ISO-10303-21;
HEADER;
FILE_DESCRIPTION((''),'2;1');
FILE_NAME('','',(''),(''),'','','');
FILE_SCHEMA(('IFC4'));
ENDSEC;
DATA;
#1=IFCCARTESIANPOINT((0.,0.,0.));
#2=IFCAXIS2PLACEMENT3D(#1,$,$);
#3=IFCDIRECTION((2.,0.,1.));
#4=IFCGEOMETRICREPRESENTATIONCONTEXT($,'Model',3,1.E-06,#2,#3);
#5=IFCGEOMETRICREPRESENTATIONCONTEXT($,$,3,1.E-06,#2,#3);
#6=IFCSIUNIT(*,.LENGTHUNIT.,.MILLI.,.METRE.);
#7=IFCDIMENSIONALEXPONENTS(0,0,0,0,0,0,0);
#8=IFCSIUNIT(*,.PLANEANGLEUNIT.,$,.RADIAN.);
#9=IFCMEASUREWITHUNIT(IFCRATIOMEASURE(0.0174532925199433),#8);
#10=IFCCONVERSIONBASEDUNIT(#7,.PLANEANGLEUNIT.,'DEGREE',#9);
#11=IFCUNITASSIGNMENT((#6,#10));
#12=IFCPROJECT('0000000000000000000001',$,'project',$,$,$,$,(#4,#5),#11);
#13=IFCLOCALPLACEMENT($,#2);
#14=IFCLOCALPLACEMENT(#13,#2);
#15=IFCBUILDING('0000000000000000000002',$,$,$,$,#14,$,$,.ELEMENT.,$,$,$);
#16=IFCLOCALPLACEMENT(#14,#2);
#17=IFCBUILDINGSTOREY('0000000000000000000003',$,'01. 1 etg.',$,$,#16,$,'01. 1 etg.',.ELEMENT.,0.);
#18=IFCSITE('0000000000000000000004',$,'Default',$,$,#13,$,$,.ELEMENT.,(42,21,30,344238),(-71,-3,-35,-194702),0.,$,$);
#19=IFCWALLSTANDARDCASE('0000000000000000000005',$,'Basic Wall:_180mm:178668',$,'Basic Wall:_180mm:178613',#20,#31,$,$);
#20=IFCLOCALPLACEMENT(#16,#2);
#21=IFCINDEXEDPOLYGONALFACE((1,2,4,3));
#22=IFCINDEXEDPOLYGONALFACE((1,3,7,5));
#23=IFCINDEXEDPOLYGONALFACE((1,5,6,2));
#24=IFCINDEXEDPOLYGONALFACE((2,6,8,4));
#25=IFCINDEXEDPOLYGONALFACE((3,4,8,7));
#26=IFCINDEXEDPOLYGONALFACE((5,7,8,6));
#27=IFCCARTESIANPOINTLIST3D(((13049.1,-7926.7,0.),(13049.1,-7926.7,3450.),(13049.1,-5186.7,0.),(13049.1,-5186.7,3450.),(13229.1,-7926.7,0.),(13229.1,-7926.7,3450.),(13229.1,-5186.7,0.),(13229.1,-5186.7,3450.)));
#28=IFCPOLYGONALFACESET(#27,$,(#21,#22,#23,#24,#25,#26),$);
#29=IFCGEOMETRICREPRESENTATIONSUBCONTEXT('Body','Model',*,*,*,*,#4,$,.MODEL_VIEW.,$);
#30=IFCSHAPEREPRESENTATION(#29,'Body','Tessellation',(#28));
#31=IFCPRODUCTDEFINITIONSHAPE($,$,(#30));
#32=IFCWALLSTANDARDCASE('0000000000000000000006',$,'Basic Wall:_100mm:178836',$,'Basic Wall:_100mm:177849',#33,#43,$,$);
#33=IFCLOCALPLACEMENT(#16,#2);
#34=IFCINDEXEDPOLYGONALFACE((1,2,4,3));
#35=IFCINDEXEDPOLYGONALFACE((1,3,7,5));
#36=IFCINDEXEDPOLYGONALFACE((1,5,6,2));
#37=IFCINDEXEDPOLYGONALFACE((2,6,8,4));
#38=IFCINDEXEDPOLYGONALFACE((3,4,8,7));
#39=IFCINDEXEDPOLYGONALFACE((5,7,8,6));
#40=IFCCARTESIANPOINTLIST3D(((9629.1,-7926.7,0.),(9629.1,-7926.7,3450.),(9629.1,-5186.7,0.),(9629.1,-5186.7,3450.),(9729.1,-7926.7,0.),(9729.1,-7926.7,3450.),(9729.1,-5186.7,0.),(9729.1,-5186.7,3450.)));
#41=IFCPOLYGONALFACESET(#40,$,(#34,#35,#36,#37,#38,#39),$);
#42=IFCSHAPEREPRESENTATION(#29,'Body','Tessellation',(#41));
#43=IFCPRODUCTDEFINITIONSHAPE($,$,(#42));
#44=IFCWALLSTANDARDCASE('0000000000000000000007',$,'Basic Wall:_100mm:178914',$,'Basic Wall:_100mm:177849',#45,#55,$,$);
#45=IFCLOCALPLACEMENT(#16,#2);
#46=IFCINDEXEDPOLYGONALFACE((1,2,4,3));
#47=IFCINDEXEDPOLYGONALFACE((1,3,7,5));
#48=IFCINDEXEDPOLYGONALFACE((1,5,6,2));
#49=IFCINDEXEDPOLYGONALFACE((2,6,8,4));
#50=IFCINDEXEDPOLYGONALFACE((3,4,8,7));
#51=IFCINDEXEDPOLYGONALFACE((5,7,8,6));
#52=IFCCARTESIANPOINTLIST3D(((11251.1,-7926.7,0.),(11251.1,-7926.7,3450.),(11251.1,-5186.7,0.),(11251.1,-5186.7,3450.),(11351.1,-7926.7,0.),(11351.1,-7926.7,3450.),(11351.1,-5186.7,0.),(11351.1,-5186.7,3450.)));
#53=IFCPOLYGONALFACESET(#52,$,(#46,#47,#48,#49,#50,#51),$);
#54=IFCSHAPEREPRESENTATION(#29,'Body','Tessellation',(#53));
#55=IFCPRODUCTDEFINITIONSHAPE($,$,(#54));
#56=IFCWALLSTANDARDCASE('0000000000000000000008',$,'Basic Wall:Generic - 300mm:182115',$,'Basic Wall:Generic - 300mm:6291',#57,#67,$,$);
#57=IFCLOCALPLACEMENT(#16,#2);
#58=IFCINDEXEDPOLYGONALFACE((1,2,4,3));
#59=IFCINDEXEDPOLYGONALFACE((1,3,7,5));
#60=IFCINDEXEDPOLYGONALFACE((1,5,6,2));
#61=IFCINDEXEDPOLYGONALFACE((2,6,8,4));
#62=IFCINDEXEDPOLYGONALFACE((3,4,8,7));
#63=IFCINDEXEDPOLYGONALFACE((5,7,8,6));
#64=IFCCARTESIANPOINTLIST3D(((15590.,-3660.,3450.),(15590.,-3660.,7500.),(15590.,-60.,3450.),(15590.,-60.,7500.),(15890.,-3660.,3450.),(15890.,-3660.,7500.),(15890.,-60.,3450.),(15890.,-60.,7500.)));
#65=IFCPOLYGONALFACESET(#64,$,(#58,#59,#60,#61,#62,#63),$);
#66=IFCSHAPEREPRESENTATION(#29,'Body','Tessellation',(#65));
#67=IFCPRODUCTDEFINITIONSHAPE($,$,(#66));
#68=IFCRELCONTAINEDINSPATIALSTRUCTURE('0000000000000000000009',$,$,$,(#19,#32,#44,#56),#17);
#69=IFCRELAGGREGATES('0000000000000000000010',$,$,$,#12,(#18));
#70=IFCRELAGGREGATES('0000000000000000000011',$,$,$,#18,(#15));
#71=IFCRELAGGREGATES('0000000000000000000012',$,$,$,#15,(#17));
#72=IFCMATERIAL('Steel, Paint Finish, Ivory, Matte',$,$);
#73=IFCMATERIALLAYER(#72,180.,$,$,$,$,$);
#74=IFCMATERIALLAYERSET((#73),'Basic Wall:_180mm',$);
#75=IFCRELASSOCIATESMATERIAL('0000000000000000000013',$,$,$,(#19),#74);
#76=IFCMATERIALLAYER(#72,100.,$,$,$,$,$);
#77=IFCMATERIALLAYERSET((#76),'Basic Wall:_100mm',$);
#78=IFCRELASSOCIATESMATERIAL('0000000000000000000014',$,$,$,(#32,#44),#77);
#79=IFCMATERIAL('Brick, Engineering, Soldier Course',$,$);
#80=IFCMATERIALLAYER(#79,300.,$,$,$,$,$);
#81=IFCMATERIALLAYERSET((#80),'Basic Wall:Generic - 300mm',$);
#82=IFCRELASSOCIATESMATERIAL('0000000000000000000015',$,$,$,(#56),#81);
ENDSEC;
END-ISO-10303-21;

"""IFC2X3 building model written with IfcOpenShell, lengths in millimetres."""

from ifc_helpers import new_model, entity, si_unit, converted_unit, direction, frame, frame_2d, origin, place, context, subcontext, project, spatial, polyline, rectangle, extrude, clip, bounded_halfspace, material, layer, layer_set, layer_usage, element, save


model = new_model("IFC2X3")

# Units and contexts
model_context = context("Model", 3, precision=1e-06, world=origin(), true_north=direction((2.0, 0.0, 1.0)))
context_of_model = context(None, 3, precision=1e-06, world=origin(), true_north=direction((2.0, 0.0, 1.0)))
body_context = subcontext(model_context, "Body", "Model", "MODEL_VIEW")
ifc_project = project(units=[si_unit("LENGTHUNIT", "METRE", prefix="MILLI"), converted_unit("PLANEANGLEUNIT", "DEGREE", entity("IfcRatioMeasure", 0.0174532925199433), si_unit("PLANEANGLEUNIT", "RADIAN"), dimensions=[0, 0, 0, 0, 0, 0, 0])], contexts=[model_context, context_of_model])

# Site, building, storey
site_placement = place(None, origin())
site = spatial("IfcSite", under=ifc_project, at=site_placement, Name="Default", CompositionType="ELEMENT", RefLatitude=(42, 21, 30, 344238), RefLongitude=(-71, -3, -35, -194702), RefElevation=0.0)
building_placement = place(site_placement, origin())
building = spatial("IfcBuilding", under=site, at=building_placement, CompositionType="ELEMENT")
storey_placement = place(building_placement, origin())
storey = spatial("IfcBuildingStorey", under=building, at=storey_placement, Name="01. 1 etg.", LongName="01. 1 etg.", CompositionType="ELEMENT", Elevation=0.0)

# Shared definitions
ifc_material_1 = material(Name="Steel, Paint Finish, Ivory, Matte")
ifc_layer_1 = layer(ifc_material_1, 100.0)
ifc_layer_set_1 = layer_set([ifc_layer_1], Name="Basic Wall:_100mm")

# Shared definitions
ifc_layer_2 = layer(ifc_material_1, 180.0)
ifc_layer_set_2 = layer_set([ifc_layer_2], Name="Basic Wall:_180mm")

# Walls
ifc_layer_usage_1 = layer_usage(ifc_layer_set_2, "AXIS2", "NEGATIVE", 90.0)
wall_1_placement = place(storey_placement, frame((13139.1, -5186.7, 0.0), z_axis=(0.0, 0.0, 1.0), x_axis=(0.0, -1.0, 0.0)))
element("IfcWallStandardCase", 1, at=wall_1_placement, inside=storey, material=ifc_layer_usage_1, Name="Basic Wall:_180mm:178668", ObjectType="Basic Wall:_180mm:178613", context=body_context, shape_type="Clipping", body=[
    clip(extrude(rectangle(XDim=2740.0, YDim=180.0, at=frame_2d((1370.0, 0.0), x_axis=(-1.0, 0.0))), origin(), (0.0, 0.0, 1.0), 3450.0), bounded_halfspace(frame((0.0, -90.0, 3450.0), z_axis=(0.0, 0.0, -1.0), x_axis=(1.0, 0.0, 0.0)), True, frame((0.0, -90.0, 3450.0)), polyline([(0.0, 0.0), (2740.0, 0.0), (2740.0, 180.0), (0.0, 180.0), (0.0, 0.0)]))),
])
ifc_layer_usage_2 = layer_usage(ifc_layer_set_1, "AXIS2", "POSITIVE", -50.0)
wall_2_placement = place(storey_placement, frame((9679.1, -5186.7, 0.0), z_axis=(0.0, 0.0, 1.0), x_axis=(0.0, -1.0, 0.0)))
element("IfcWallStandardCase", 2, at=wall_2_placement, inside=storey, material=ifc_layer_usage_2, Name="Basic Wall:_100mm:178836", ObjectType="Basic Wall:_100mm:177849", context=body_context, shape_type="Clipping", body=[
    clip(extrude(rectangle(XDim=2740.0, YDim=100.0, at=frame_2d((1370.0, 0.0), x_axis=(-1.0, 0.0))), origin(), (0.0, 0.0, 1.0), 3450.0), bounded_halfspace(frame((0.0, -50.0, 3450.0), z_axis=(0.0, 0.0, -1.0), x_axis=(1.0, 0.0, 0.0)), True, frame((0.0, -50.0, 3450.0)), polyline([(0.0, 0.0), (2740.0, 0.0), (2740.0, 100.0), (0.0, 100.0), (0.0, 0.0)]))),
])
ifc_layer_usage_3 = layer_usage(ifc_layer_set_1, "AXIS2", "NEGATIVE", 50.0)
wall_3_placement = place(storey_placement, frame((11301.1, -5186.7, 0.0), z_axis=(0.0, 0.0, 1.0), x_axis=(0.0, -1.0, 0.0)))
element("IfcWallStandardCase", 3, at=wall_3_placement, inside=storey, material=ifc_layer_usage_3, Name="Basic Wall:_100mm:178914", ObjectType="Basic Wall:_100mm:177849", context=body_context, shape_type="Clipping", body=[
    clip(extrude(rectangle(XDim=2740.0, YDim=100.0, at=frame_2d((1370.0, 0.0), x_axis=(-1.0, 0.0))), origin(), (0.0, 0.0, 1.0), 3450.0), bounded_halfspace(frame((0.0, -50.0, 3450.0), z_axis=(0.0, 0.0, -1.0), x_axis=(1.0, 0.0, 0.0)), True, frame((0.0, -50.0, 3450.0)), polyline([(0.0, 0.0), (2740.0, 0.0), (2740.0, 100.0), (0.0, 100.0), (0.0, 0.0)]))),
])
ifc_material_2 = material(Name="Brick, Engineering, Soldier Course")
ifc_layer_3 = layer(ifc_material_2, 300.0)
ifc_layer_set_3 = layer_set([ifc_layer_3], Name="Basic Wall:Generic - 300mm")
ifc_layer_usage_4 = layer_usage(ifc_layer_set_3, "AXIS2", "POSITIVE", -150.0)
wall_4_placement = place(storey_placement, frame((15740.0, -3660.0, 3450.0), z_axis=(0.0, 0.0, 1.0), x_axis=(0.0, 1.0, 0.0)))
element("IfcWallStandardCase", 4, at=wall_4_placement, inside=storey, material=ifc_layer_usage_4, Name="Basic Wall:Generic - 300mm:182115", ObjectType="Basic Wall:Generic - 300mm:6291", context=body_context, shape_type="SweptSolid", body=[
    extrude(rectangle(XDim=3600.0, YDim=300.0, at=frame_2d((1800.0, 0.0), x_axis=(-1.0, 0.0))), origin(), (0.0, 0.0, 1.0), 4050.0),
])

save(model, "model.ifc")
